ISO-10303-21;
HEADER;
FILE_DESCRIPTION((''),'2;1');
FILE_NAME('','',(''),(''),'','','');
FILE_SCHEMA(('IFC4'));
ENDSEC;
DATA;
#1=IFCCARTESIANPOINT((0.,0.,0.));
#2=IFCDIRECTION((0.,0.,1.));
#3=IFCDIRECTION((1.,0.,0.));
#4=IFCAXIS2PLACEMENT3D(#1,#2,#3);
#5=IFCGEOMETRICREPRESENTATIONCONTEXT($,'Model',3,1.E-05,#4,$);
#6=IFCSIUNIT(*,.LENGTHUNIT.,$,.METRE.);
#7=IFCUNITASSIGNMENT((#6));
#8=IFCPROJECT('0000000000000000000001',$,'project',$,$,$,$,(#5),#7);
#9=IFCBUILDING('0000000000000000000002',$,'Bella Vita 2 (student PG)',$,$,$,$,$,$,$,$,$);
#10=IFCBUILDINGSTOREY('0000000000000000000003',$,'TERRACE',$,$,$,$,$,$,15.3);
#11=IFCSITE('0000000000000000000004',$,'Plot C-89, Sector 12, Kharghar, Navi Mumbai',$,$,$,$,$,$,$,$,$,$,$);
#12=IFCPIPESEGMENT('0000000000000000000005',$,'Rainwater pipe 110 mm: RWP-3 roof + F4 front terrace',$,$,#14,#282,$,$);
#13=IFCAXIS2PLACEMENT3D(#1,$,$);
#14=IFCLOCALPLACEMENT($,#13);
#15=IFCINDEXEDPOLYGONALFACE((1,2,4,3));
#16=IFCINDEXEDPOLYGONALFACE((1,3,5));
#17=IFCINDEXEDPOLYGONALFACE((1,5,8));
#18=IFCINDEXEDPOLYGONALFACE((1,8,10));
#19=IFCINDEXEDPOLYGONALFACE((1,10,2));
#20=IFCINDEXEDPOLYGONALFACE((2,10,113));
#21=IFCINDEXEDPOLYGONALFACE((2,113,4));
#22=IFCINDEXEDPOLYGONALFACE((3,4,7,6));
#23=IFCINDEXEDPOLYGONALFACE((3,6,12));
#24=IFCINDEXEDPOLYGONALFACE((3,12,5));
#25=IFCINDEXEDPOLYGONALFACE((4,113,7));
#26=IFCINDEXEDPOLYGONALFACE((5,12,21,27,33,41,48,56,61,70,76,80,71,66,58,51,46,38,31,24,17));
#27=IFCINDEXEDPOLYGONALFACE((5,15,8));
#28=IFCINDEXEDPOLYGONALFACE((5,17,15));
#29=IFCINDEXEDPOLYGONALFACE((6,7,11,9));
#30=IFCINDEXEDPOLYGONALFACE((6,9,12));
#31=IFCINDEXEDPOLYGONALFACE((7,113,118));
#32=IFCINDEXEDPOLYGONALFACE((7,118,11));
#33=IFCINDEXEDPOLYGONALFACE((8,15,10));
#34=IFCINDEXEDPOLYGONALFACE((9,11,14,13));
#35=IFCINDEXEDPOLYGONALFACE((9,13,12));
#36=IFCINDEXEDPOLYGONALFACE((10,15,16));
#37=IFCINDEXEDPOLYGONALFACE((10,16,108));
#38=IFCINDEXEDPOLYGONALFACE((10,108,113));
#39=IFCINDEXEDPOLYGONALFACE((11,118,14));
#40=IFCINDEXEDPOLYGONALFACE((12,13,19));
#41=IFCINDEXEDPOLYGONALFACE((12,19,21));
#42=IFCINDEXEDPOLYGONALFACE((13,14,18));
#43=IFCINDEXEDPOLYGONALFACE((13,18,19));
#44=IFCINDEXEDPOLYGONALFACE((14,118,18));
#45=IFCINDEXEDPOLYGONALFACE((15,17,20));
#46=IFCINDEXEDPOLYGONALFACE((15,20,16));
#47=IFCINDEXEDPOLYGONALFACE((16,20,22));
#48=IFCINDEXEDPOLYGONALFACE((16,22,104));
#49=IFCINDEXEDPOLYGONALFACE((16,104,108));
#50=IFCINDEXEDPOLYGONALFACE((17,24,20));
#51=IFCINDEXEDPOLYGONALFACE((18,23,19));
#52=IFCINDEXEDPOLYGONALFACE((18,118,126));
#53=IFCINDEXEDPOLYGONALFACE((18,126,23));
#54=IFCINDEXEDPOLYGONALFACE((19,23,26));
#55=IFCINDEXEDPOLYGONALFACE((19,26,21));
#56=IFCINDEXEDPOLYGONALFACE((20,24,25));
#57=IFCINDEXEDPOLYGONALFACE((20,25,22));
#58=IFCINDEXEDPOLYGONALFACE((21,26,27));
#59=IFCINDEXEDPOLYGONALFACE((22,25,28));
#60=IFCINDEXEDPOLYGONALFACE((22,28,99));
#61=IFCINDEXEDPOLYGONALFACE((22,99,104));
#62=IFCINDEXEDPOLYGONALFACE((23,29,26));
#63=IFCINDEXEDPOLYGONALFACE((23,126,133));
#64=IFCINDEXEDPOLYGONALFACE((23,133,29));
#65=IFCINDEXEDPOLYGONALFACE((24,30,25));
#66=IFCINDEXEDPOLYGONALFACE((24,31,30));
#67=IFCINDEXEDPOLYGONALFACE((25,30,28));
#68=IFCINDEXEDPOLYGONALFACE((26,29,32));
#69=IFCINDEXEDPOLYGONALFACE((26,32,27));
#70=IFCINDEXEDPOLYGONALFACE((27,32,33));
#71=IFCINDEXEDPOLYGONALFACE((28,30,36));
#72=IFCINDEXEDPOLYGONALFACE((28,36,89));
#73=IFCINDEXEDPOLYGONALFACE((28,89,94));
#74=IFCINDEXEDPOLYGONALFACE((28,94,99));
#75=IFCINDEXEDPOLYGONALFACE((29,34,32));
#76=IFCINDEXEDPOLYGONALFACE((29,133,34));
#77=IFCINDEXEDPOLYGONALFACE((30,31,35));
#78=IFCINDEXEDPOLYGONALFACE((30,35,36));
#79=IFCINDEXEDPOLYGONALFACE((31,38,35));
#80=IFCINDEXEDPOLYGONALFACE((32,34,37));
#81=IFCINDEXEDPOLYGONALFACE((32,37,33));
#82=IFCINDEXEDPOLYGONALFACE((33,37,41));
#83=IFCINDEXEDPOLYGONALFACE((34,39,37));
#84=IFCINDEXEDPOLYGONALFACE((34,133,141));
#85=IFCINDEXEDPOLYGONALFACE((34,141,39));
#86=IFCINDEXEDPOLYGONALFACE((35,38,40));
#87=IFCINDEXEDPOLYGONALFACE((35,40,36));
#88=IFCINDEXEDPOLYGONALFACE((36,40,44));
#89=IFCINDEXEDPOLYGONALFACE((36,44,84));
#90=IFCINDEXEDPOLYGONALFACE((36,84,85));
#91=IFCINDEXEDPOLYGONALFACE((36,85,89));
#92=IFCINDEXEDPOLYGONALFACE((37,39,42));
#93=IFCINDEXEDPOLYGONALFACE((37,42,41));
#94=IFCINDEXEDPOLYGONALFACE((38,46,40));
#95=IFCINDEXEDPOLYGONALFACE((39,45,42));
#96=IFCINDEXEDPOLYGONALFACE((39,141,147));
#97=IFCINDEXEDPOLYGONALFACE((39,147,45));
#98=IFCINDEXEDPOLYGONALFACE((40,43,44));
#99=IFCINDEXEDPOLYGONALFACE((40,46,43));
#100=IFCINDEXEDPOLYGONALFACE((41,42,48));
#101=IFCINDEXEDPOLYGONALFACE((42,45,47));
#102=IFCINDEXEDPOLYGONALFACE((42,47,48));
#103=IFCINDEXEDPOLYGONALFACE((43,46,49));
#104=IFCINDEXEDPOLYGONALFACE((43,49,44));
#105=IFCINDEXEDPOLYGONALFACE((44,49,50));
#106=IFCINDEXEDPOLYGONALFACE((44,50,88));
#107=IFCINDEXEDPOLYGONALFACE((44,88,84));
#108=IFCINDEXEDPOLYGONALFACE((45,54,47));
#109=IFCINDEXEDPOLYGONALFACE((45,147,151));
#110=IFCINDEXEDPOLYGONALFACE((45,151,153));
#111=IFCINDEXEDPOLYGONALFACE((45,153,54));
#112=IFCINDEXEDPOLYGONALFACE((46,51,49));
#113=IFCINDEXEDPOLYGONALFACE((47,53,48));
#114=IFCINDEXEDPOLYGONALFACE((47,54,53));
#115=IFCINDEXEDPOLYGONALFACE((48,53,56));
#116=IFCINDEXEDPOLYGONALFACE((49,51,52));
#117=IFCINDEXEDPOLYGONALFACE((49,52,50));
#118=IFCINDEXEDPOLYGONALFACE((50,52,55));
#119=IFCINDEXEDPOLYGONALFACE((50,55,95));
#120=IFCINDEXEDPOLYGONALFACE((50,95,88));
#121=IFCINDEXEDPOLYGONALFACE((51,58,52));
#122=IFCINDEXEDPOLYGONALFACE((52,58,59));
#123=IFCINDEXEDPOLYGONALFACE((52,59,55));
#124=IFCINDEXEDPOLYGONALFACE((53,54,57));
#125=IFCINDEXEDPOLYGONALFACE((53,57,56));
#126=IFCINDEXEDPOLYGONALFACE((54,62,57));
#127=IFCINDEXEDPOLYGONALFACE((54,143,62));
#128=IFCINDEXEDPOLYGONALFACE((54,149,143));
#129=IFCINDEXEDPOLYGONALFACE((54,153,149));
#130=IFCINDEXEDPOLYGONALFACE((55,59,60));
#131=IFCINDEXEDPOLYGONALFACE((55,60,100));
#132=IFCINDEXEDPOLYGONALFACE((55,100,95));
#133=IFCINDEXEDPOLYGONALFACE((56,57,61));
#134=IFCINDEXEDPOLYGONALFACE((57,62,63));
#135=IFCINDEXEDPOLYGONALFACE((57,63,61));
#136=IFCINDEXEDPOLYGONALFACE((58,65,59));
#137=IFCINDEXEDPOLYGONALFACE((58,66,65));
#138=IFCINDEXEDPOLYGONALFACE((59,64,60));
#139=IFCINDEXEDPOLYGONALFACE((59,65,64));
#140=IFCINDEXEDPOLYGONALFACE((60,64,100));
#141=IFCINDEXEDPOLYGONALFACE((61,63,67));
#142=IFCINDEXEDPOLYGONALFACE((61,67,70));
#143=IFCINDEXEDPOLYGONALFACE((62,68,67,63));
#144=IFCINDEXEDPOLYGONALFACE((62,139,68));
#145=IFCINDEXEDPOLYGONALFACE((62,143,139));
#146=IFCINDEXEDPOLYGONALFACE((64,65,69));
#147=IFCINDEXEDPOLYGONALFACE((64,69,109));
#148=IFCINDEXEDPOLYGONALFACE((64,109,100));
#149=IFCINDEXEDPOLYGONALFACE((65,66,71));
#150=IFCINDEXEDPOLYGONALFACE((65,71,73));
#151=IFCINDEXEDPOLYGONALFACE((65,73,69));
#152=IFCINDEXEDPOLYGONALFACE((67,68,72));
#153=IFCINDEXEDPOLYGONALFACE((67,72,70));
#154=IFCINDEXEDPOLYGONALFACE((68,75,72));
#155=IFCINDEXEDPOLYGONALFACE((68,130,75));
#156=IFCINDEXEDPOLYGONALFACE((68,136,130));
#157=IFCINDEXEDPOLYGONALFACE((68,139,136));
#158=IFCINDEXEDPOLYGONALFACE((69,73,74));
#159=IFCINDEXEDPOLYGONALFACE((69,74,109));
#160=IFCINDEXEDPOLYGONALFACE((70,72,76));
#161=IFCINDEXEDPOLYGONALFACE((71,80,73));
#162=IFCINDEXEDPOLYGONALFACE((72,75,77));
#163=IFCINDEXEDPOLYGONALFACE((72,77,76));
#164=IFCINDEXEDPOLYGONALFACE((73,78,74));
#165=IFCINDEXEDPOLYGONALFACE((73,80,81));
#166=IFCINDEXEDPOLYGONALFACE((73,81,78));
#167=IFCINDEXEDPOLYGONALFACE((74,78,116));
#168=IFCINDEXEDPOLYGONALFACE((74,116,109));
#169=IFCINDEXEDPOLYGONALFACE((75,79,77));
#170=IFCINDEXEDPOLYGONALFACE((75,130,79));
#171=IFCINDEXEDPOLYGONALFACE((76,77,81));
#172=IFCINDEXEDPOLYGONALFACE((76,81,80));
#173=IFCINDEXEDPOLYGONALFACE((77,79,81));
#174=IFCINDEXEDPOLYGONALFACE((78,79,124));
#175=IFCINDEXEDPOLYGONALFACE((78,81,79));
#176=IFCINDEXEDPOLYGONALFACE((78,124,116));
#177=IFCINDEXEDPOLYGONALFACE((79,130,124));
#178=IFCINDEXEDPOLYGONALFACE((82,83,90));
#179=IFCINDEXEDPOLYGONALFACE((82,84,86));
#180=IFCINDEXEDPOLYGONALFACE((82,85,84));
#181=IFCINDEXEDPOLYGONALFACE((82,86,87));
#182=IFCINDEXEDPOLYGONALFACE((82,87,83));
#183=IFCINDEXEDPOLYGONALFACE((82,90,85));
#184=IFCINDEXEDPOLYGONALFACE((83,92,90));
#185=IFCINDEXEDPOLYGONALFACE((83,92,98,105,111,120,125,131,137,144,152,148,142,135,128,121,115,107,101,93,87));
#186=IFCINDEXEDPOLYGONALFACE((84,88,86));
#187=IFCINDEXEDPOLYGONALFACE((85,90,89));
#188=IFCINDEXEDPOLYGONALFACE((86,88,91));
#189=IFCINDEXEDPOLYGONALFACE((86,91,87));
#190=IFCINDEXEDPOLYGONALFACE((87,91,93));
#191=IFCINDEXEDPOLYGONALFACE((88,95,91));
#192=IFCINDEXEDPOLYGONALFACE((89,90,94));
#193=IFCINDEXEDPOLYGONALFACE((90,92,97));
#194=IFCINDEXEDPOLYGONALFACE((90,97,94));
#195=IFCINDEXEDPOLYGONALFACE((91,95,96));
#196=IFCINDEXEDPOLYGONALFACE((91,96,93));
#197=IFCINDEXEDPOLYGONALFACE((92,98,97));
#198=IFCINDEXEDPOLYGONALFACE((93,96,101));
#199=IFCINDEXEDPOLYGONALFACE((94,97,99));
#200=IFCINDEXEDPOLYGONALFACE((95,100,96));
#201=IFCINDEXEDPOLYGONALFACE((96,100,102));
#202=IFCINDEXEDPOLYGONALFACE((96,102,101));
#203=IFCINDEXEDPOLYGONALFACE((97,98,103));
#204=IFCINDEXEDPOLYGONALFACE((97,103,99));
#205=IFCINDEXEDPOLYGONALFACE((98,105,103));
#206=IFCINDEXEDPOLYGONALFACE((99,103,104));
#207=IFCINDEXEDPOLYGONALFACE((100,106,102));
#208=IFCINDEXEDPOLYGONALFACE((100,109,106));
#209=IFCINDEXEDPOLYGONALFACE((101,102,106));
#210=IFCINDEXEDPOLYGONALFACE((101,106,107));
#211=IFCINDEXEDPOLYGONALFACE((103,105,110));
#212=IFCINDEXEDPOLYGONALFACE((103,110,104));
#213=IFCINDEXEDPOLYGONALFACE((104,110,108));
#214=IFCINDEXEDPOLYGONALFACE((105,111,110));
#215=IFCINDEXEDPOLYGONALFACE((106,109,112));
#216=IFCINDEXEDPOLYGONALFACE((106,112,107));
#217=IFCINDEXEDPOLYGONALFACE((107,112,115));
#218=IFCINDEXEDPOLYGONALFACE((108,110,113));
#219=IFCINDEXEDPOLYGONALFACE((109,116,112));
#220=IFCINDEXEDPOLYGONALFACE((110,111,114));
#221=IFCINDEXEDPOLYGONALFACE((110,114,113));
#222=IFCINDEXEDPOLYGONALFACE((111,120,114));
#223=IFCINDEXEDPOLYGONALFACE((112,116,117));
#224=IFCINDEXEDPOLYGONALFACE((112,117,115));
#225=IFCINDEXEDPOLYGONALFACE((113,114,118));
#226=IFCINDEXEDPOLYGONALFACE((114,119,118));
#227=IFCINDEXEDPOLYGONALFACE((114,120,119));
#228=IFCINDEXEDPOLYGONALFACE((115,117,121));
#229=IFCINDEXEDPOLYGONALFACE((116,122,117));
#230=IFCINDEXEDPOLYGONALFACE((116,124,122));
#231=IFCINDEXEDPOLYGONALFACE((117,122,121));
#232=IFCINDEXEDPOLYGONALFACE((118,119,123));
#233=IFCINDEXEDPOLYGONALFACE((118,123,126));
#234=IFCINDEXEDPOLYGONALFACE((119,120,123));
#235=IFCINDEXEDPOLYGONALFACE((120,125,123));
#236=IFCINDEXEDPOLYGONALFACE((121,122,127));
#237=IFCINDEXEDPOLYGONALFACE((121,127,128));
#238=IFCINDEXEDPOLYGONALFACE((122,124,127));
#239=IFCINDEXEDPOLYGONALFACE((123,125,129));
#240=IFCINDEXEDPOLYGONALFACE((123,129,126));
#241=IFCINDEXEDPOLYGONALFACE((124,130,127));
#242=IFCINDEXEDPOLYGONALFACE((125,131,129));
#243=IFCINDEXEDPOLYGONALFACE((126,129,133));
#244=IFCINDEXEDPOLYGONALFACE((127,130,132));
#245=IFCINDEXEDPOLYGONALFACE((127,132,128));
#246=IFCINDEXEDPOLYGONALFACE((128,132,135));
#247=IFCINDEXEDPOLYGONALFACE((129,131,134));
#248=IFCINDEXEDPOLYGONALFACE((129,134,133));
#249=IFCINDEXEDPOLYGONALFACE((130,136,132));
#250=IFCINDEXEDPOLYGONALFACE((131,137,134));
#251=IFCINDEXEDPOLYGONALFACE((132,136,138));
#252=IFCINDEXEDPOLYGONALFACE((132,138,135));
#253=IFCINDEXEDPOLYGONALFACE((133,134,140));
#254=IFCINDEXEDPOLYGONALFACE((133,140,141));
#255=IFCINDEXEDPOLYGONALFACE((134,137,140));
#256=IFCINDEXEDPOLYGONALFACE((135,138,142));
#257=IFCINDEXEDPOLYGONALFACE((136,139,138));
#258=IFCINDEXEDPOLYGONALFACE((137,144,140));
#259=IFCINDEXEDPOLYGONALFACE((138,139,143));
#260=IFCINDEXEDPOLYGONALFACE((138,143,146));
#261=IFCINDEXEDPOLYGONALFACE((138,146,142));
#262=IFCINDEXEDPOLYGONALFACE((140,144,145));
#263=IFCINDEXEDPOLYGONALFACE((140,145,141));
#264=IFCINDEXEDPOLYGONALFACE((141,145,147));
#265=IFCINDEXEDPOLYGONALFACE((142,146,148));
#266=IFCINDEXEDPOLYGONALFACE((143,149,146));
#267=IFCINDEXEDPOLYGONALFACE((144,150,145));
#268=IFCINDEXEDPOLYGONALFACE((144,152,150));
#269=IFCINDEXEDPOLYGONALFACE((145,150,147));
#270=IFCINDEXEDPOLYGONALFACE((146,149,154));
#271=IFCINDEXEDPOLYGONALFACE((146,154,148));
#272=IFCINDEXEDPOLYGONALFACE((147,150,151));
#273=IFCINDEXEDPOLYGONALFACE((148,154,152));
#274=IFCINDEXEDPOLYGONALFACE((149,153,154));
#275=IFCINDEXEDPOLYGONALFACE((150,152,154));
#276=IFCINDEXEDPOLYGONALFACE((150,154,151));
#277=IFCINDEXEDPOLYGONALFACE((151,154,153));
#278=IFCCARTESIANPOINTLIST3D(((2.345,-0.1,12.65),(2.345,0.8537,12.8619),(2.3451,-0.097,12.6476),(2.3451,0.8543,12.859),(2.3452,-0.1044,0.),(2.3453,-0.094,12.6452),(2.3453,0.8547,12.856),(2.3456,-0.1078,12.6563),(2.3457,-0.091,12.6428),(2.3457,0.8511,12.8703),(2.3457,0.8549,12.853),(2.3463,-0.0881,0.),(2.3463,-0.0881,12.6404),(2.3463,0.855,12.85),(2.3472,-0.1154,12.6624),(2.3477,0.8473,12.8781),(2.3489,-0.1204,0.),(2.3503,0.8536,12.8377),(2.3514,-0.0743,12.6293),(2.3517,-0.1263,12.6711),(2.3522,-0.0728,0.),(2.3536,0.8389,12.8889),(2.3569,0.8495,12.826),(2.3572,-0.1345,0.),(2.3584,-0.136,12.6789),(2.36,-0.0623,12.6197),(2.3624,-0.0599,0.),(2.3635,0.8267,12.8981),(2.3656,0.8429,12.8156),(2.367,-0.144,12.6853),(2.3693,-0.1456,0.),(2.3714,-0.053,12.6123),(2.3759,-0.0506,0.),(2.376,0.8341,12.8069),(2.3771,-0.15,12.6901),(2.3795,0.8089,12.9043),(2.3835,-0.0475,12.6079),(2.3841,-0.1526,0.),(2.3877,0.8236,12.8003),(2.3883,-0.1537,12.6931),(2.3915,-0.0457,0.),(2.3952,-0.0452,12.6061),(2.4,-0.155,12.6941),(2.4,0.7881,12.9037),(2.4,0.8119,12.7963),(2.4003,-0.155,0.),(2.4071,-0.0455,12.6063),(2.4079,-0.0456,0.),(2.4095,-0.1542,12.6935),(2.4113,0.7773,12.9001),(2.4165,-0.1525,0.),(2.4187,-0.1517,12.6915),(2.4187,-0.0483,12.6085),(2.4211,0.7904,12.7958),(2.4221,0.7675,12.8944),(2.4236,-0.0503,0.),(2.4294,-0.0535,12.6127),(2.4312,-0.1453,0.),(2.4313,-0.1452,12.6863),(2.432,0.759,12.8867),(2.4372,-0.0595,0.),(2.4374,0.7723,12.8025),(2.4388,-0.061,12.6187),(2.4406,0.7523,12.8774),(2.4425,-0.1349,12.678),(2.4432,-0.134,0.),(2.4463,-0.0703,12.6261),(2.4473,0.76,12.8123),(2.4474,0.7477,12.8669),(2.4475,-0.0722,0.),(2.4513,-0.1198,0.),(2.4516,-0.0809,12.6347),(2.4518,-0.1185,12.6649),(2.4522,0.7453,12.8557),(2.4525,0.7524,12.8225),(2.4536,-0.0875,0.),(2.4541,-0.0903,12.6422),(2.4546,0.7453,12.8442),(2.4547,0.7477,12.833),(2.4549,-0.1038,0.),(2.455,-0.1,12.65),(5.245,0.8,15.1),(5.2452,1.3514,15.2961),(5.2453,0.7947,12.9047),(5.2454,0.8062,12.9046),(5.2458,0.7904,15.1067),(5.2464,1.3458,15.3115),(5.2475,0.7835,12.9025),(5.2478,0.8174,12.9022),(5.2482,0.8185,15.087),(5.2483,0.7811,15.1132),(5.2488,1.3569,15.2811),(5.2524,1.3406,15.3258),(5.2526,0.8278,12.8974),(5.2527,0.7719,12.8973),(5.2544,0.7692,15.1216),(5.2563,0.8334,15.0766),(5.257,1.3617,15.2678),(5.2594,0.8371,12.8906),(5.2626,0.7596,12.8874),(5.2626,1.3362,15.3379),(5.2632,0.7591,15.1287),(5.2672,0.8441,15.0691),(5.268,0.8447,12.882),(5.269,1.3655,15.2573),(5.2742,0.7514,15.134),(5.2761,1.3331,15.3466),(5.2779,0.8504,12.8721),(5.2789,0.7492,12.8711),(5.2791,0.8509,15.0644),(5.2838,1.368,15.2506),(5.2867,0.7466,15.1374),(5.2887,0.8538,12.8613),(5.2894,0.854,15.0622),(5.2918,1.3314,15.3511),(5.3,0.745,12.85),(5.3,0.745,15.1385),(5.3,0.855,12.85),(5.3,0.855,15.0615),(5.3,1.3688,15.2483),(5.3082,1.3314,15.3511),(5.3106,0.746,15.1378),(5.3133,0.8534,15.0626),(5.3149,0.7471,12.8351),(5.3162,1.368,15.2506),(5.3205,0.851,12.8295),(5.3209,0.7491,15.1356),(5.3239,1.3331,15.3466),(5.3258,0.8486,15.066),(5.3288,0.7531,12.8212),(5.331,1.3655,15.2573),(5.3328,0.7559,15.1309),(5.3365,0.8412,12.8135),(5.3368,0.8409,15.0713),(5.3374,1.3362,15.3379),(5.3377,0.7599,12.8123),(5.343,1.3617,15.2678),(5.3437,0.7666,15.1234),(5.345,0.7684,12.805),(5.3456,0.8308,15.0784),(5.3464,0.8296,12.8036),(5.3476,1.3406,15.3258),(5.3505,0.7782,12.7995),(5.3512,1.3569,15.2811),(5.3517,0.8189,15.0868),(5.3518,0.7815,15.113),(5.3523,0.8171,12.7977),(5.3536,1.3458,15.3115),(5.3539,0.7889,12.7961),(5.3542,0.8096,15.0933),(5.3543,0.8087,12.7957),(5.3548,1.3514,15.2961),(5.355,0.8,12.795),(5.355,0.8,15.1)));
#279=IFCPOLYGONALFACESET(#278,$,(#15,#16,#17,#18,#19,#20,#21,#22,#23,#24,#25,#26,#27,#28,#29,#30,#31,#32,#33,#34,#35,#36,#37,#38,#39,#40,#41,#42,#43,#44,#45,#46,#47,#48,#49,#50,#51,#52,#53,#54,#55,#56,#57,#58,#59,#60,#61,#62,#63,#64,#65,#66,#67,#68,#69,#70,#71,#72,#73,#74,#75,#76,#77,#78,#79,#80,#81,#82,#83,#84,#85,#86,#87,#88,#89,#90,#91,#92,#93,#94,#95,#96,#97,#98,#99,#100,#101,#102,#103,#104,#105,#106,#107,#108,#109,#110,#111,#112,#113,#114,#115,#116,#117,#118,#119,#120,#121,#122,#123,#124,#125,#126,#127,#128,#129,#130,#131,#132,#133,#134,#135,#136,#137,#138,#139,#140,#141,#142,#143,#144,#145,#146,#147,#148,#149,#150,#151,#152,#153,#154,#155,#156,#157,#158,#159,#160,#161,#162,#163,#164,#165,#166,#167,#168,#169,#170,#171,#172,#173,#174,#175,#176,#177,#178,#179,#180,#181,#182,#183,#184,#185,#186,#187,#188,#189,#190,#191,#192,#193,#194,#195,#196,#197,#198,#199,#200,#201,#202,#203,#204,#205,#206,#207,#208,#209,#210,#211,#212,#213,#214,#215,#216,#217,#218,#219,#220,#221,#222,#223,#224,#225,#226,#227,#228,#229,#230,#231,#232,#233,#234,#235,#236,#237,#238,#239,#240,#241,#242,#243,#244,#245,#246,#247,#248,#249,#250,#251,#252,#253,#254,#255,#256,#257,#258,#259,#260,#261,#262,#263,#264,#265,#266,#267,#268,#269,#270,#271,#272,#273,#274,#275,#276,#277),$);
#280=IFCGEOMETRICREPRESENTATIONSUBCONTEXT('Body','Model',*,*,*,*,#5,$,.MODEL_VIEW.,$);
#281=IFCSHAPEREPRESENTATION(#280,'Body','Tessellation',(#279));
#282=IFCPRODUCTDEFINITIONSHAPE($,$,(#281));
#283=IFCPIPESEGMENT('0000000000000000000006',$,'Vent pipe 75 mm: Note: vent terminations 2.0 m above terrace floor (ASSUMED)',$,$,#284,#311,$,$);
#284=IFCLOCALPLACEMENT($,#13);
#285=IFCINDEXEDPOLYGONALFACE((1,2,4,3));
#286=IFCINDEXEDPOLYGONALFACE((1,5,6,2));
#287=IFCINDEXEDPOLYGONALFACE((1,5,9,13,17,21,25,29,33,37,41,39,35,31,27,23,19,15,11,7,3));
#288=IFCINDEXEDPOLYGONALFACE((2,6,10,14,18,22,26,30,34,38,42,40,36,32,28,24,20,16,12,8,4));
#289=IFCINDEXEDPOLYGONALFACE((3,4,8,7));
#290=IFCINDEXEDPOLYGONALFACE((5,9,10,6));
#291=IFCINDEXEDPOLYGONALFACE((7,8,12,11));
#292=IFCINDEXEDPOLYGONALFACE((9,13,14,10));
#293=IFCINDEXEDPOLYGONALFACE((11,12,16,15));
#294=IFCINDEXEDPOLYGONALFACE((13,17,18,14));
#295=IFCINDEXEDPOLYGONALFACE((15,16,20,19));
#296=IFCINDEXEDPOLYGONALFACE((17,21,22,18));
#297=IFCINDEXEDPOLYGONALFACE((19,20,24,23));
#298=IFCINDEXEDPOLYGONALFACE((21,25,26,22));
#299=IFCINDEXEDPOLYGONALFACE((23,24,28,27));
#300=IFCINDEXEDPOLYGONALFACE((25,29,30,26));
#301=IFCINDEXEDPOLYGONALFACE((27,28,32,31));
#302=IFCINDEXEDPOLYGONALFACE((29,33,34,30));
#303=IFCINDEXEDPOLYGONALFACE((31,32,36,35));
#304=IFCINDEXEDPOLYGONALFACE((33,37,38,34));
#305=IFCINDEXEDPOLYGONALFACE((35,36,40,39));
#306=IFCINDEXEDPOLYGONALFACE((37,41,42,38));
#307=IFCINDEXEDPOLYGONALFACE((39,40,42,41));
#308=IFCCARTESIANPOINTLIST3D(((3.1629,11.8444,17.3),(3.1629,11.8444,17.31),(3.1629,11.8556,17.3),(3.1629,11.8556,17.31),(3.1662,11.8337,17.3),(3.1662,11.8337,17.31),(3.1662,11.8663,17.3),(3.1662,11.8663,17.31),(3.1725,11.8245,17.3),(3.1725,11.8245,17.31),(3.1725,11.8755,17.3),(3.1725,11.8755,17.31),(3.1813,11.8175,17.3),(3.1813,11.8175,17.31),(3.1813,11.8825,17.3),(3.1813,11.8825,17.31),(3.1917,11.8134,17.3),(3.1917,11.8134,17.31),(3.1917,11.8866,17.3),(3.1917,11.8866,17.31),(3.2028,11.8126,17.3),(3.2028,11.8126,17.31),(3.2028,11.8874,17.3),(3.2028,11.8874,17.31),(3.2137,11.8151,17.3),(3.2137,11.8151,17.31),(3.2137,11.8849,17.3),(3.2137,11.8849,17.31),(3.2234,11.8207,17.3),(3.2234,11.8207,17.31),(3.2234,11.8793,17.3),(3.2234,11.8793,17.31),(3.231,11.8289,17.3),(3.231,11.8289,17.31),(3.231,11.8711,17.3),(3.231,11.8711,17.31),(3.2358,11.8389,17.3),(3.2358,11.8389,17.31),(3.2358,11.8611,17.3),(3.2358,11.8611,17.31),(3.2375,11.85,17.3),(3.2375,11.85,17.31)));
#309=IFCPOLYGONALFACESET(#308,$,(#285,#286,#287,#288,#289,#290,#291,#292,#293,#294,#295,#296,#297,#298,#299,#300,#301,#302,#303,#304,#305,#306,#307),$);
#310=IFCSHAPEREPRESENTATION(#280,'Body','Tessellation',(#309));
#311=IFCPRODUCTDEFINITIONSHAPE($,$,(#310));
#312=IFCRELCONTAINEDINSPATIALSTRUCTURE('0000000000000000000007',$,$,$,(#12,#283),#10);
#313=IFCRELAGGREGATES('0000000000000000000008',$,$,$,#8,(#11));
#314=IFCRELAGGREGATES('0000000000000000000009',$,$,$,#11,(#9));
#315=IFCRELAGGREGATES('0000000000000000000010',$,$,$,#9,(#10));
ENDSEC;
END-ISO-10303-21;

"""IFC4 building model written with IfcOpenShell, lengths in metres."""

from ifc_helpers import new_model, entity, si_unit, origin, origin_with_axes, place, context, subcontext, project, spatial, element, save


model = new_model("IFC4")

# Units and contexts
model_context = context("Model", 3, precision=1e-05, world=origin_with_axes())
body_context = subcontext(model_context, "Body", "Model", "MODEL_VIEW")
ifc_project = project(units=[si_unit("LENGTHUNIT", "METRE")], contexts=[model_context])

# Site, building, storey
site = spatial("IfcSite", under=ifc_project, Name="Plot C-89, Sector 12, Kharghar, Navi Mumbai")
building = spatial("IfcBuilding", under=site, Name="Bella Vita 2 (student PG)")
storey = spatial("IfcBuildingStorey", under=building, Name="TERRACE", Elevation=15.3)

# Pipe segments
pipe_segment_1_placement = place(None, origin())
element("IfcPipeSegment", 1, at=pipe_segment_1_placement, inside=storey, Name="Rainwater pipe 110 mm: RWP-3 roof + F4 front terrace", context=body_context, shape_type="AdvancedSweptSolid", body=[
    entity("IfcSweptDiskSolid", entity("IfcPolyline", [entity("IfcCartesianPoint", [5.3, 1.35, 15.3]), entity("IfcCartesianPoint", [5.3, 0.8, 15.1]), entity("IfcCartesianPoint", [5.3, 0.8, 12.85]), entity("IfcCartesianPoint", [2.4, 0.8, 12.85]), entity("IfcCartesianPoint", [2.4, -0.1, 12.65]), entity("IfcCartesianPoint", [2.4, -0.1, 0.0])]), 0.055),
])
pipe_segment_2_placement = place(None, origin())
element("IfcPipeSegment", 2, at=pipe_segment_2_placement, inside=storey, Name="Vent pipe 75 mm: Note: vent terminations 2.0 m above terrace floor (ASSUMED)", context=body_context, shape_type="AdvancedSweptSolid", body=[
    entity("IfcSweptDiskSolid", entity("IfcPolyline", [entity("IfcCartesianPoint", [3.2, 11.85, 17.3]), entity("IfcCartesianPoint", [3.2, 11.85, 17.31])]), 0.0375),
])

save(model, "model.ifc")
